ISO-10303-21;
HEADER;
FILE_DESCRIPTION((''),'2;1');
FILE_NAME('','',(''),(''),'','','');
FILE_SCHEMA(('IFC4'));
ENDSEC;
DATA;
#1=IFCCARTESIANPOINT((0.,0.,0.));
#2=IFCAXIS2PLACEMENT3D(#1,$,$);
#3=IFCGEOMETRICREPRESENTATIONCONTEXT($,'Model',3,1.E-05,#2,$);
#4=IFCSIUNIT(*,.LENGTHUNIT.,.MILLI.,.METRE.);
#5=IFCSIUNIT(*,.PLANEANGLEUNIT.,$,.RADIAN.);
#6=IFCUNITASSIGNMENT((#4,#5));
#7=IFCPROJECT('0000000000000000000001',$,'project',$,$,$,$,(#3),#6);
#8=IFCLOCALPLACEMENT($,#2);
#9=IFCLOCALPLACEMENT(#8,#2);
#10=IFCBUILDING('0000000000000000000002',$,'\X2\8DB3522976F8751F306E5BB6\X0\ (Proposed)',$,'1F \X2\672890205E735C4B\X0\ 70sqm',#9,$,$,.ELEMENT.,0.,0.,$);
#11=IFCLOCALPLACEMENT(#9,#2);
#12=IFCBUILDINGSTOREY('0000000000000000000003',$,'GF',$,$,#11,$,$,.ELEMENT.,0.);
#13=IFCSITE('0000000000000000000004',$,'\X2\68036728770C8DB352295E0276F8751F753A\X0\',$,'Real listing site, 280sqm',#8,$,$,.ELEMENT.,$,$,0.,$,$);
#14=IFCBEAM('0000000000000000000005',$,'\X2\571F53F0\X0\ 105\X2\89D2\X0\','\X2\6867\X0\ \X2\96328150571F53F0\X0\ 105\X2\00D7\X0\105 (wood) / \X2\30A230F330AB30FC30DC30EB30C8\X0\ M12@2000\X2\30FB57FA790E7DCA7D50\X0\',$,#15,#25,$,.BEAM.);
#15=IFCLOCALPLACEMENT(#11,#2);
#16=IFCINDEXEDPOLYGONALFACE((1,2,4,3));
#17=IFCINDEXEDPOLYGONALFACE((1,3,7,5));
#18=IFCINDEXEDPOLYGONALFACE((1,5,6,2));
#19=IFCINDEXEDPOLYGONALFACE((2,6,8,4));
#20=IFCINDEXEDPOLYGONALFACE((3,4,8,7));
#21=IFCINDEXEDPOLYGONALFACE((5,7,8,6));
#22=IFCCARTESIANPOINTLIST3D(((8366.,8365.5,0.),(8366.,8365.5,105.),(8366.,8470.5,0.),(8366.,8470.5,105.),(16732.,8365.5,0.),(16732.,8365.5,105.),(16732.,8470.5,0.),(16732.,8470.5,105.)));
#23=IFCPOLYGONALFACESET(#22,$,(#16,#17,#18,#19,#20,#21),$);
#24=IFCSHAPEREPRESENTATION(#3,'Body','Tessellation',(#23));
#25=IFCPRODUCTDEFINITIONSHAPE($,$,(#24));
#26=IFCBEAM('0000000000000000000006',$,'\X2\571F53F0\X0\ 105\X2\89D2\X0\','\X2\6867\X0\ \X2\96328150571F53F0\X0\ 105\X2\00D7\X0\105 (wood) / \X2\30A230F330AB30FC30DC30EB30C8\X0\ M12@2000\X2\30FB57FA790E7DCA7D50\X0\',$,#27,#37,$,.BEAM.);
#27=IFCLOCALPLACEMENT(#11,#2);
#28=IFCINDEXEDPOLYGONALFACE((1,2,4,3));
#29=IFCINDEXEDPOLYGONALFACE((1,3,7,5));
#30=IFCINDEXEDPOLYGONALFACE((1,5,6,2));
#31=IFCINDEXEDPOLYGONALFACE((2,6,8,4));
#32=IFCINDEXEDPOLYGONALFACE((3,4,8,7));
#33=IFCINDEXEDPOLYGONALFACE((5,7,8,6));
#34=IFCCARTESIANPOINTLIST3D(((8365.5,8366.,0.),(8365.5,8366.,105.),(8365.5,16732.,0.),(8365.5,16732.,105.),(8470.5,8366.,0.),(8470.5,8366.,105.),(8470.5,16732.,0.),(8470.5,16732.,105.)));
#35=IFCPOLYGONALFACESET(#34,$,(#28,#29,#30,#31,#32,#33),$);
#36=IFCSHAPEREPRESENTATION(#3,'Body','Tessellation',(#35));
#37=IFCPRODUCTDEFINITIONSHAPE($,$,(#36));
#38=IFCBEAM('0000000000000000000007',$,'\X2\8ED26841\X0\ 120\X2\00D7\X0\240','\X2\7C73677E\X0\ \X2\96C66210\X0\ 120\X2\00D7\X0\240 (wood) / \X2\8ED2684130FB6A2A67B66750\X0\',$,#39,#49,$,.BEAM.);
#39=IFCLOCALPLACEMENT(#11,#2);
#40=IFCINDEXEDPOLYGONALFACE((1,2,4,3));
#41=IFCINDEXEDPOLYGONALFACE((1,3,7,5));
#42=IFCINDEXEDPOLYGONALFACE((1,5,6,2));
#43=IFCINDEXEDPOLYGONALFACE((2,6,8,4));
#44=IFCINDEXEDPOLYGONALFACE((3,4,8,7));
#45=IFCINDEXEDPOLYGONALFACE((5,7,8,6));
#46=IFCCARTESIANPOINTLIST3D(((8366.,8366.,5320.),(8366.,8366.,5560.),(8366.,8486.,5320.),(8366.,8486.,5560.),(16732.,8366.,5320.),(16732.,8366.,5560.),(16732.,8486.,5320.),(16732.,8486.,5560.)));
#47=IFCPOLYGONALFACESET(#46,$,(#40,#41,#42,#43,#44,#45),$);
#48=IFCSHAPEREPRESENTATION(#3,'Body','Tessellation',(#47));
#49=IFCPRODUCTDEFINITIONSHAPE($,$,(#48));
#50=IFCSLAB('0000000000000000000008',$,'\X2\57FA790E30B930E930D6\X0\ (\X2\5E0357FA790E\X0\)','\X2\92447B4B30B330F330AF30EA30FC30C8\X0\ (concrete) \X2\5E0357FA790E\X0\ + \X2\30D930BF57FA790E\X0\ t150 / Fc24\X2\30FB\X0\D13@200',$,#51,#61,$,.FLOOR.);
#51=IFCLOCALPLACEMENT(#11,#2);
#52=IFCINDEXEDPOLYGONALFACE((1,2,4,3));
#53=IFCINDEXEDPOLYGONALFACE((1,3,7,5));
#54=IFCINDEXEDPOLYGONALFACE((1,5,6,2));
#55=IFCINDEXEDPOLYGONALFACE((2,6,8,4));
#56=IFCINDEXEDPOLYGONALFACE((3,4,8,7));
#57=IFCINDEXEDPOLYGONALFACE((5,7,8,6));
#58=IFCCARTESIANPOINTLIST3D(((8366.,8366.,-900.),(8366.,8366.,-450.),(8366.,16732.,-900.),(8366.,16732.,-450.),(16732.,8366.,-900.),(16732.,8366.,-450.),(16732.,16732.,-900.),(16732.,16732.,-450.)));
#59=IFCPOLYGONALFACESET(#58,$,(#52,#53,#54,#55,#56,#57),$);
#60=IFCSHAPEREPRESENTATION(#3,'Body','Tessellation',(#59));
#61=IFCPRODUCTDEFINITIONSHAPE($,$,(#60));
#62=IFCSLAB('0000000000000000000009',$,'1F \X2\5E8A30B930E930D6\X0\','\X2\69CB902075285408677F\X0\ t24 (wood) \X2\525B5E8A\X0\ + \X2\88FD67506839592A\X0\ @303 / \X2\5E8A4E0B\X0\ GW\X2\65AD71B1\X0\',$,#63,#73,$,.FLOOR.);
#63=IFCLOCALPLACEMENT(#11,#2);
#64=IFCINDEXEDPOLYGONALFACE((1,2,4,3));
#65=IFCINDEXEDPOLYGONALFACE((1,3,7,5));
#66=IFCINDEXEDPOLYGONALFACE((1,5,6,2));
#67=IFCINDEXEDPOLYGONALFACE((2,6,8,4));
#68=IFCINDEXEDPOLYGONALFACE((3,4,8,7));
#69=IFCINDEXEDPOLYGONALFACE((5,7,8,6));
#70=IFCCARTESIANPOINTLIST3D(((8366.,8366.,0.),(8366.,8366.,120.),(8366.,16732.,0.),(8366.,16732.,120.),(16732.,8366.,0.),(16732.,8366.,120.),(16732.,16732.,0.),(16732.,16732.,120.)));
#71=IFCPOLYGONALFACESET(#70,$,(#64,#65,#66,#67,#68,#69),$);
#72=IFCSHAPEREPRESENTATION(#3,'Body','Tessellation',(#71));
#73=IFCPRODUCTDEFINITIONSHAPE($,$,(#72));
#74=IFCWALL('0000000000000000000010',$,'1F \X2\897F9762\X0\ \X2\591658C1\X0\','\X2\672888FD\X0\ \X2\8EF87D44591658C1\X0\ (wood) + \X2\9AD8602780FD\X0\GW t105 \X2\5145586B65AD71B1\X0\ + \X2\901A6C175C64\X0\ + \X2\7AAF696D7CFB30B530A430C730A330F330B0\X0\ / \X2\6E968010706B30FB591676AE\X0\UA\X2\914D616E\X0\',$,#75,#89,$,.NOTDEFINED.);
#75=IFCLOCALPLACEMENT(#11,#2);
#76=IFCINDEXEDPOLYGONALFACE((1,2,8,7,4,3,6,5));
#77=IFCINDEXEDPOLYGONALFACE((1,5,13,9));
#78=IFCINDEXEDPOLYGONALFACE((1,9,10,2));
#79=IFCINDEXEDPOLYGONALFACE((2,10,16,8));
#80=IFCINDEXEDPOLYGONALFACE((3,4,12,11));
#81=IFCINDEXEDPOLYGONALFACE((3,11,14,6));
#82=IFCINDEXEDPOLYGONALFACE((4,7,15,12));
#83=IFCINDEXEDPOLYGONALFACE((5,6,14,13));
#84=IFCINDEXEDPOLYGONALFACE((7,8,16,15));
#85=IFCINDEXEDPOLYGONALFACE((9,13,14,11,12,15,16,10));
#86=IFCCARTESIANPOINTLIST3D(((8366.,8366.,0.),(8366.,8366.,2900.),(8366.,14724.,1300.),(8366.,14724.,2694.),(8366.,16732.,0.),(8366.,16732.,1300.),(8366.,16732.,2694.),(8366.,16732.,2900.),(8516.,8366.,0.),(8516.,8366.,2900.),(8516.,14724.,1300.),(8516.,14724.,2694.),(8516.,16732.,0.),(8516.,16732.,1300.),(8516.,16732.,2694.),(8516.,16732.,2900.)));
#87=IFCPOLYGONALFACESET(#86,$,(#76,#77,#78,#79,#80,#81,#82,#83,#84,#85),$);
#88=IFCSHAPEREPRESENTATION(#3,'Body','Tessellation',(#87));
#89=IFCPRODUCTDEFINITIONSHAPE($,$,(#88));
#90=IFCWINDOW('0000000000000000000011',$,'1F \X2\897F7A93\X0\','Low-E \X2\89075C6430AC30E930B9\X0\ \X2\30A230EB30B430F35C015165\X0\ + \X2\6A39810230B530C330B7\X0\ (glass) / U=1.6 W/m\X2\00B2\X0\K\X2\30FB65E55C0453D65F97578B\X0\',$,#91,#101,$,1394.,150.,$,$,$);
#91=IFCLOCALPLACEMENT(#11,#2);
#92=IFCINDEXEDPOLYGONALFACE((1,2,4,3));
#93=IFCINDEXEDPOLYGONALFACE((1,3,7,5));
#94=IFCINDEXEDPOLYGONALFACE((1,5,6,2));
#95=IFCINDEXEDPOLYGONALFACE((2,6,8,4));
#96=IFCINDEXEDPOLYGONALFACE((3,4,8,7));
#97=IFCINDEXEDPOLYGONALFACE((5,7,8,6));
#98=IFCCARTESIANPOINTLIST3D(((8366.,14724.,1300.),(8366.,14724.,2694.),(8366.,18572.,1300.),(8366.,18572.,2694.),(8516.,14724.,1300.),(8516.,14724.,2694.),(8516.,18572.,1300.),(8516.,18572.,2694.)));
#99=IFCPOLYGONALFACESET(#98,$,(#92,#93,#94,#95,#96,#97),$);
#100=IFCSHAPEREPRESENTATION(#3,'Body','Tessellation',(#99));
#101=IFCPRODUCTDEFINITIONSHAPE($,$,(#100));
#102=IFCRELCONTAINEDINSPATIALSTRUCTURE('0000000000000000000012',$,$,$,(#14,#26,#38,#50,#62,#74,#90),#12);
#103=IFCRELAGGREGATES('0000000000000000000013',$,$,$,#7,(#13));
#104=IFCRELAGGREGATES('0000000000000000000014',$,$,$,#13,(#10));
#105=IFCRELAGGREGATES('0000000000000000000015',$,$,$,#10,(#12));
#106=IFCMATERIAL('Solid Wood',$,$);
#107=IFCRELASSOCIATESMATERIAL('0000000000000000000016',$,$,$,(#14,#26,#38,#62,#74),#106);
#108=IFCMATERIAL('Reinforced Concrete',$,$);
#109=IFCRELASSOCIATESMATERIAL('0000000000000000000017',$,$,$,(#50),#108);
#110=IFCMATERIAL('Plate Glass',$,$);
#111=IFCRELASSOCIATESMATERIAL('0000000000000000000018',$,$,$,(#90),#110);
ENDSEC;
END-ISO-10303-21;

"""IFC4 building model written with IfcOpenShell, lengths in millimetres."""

from ifc_helpers import new_model, si_unit, frame, frame_2d, origin, place, context, project, spatial, rectangle, extrude, material, element, fill, save


model = new_model("IFC4")

# Units and contexts
model_context = context("Model", 3, precision=1e-05, world=origin())
ifc_project = project(units=[si_unit("LENGTHUNIT", "METRE", prefix="MILLI"), si_unit("PLANEANGLEUNIT", "RADIAN")], contexts=[model_context])

# Site, building, storey
site_placement = place(None, origin())
site = spatial("IfcSite", under=ifc_project, at=site_placement, Name="栃木県足利市相生町", ObjectType="Real listing site, 280sqm", CompositionType="ELEMENT", RefElevation=0.0)
building_placement = place(site_placement, origin())
building = spatial("IfcBuilding", under=site, at=building_placement, Name="足利相生の家 (Proposed)", ObjectType="1F 木造平屋 70sqm", CompositionType="ELEMENT", ElevationOfRefHeight=0.0, ElevationOfTerrain=0.0)
storey_placement = place(building_placement, origin())
storey = spatial("IfcBuildingStorey", under=building, at=storey_placement, Name="GF", CompositionType="ELEMENT", Elevation=0.0)

# Shared definitions
ifc_material_1 = material(Name="Solid Wood")

# Beams
beam_1_placement = place(storey_placement, frame((4183.0, 4183.0, 0.0)))
element("IfcBeam", 1, at=beam_1_placement, inside=storey, material=ifc_material_1, Name="土台 105角", Description="桧 防腐土台 105×105 (wood) / アンカーボルト M12@2000・基礎緊結", PredefinedType="BEAM", context=model_context, shape_type="SweptSolid", body=[
    extrude(rectangle(XDim=8366.0, YDim=105.0, at=frame_2d((4183.0, 52.0))), frame((4183.0, 4183.0, 0.0)), (0.0, 0.0, 1.0), 105.0),
])
beam_2_placement = place(storey_placement, frame((4183.0, 4183.0, 0.0)))
element("IfcBeam", 2, at=beam_2_placement, inside=storey, material=ifc_material_1, Name="土台 105角", Description="桧 防腐土台 105×105 (wood) / アンカーボルト M12@2000・基礎緊結", PredefinedType="BEAM", context=model_context, shape_type="SweptSolid", body=[
    extrude(rectangle(XDim=105.0, YDim=8366.0, at=frame_2d((52.0, 4183.0))), frame((4183.0, 4183.0, 0.0)), (0.0, 0.0, 1.0), 105.0),
])
beam_3_placement = place(storey_placement, frame((4183.0, 4183.0, 2660.0)))
element("IfcBeam", 3, at=beam_3_placement, inside=storey, material=ifc_material_1, Name="軒桁 120×240", Description="米松 集成 120×240 (wood) / 軒桁・横架材", PredefinedType="BEAM", context=model_context, shape_type="SweptSolid", body=[
    extrude(rectangle(XDim=8366.0, YDim=120.0, at=frame_2d((4183.0, 60.0))), frame((4183.0, 4183.0, 2660.0)), (0.0, 0.0, 1.0), 240.0),
])

# Slabs
ifc_material_2 = material(Name="Reinforced Concrete")
slab_1_placement = place(storey_placement, frame((4183.0, 4183.0, -450.0)))
element("IfcSlab", 4, at=slab_1_placement, inside=storey, material=ifc_material_2, Name="基礎スラブ (布基礎)", Description="鉄筋コンクリート (concrete) 布基礎 + ベタ基礎 t150 / Fc24・D13@200", PredefinedType="FLOOR", context=model_context, shape_type="SweptSolid", body=[
    extrude(rectangle(XDim=8366.0, YDim=8366.0, at=frame_2d((4183.0, 4183.0))), frame((4183.0, 4183.0, -450.0)), (0.0, 0.0, 1.0), 450.0),
])
slab_2_placement = place(storey_placement, frame((4183.0, 4183.0, 0.0)))
element("IfcSlab", 5, at=slab_2_placement, inside=storey, material=ifc_material_1, Name="1F 床スラブ", Description="構造用合板 t24 (wood) 剛床 + 製材根太 @303 / 床下 GW断熱", PredefinedType="FLOOR", context=model_context, shape_type="SweptSolid", body=[
    extrude(rectangle(XDim=8366.0, YDim=8366.0, at=frame_2d((4183.0, 4183.0))), frame((4183.0, 4183.0, 0.0)), (0.0, 0.0, 1.0), 120.0),
])

# Shared definitions
ifc_material_3 = material(Name="Plate Glass")

# Wall, opening, window
wall_1_placement = place(storey_placement, frame((4183.0, 4183.0, 0.0)))
wall_1 = element("IfcWall", 6, at=wall_1_placement, inside=storey, material=ifc_material_1, Name="1F 西面 外壁", Description="木製 軸組外壁 (wood) + 高性能GW t105 充填断熱 + 通気層 + 窯業系サイディング / 準耐火・外皮UA配慮", PredefinedType="NOTDEFINED", context=model_context, shape_type="SweptSolid", body=[
    extrude(rectangle(XDim=150.0, YDim=8366.0, at=frame_2d((75.0, 4183.0))), frame((4183.0, 4183.0, 0.0)), (0.0, 0.0, 1.0), 2900.0),
])
opening_1_placement = place(storey_placement, frame((4183.0, 7362.0, 650.0)))
opening_1 = element("IfcOpeningElement", 7, at=opening_1_placement, cuts=wall_1, PredefinedType="NOTDEFINED", context=model_context, shape_type="SweptSolid", body=[
    extrude(rectangle(XDim=150.0, YDim=3848.0, at=frame_2d((75.0, 1924.0))), frame((4183.0, 7362.0, 650.0)), (0.0, 0.0, 1.0), 1394.0),
])
window_1_placement = place(storey_placement, frame((4183.0, 7362.0, 650.0)))
window_1 = element("IfcWindow", 8, at=window_1_placement, inside=storey, material=ifc_material_3, Name="1F 西窓", Description="Low-E 複層ガラス アルゴン封入 + 樹脂サッシ (glass) / U=1.6 W/m²K・日射取得型", OverallHeight=1394.0, OverallWidth=150.0, context=model_context, shape_type="SweptSolid", body=[
    extrude(rectangle(XDim=150.0, YDim=3848.0, at=frame_2d((75.0, 1924.0))), frame((4183.0, 7362.0, 650.0)), (0.0, 0.0, 1.0), 1394.0),
])
fill(opening_1, window_1)

save(model, "model.ifc")
